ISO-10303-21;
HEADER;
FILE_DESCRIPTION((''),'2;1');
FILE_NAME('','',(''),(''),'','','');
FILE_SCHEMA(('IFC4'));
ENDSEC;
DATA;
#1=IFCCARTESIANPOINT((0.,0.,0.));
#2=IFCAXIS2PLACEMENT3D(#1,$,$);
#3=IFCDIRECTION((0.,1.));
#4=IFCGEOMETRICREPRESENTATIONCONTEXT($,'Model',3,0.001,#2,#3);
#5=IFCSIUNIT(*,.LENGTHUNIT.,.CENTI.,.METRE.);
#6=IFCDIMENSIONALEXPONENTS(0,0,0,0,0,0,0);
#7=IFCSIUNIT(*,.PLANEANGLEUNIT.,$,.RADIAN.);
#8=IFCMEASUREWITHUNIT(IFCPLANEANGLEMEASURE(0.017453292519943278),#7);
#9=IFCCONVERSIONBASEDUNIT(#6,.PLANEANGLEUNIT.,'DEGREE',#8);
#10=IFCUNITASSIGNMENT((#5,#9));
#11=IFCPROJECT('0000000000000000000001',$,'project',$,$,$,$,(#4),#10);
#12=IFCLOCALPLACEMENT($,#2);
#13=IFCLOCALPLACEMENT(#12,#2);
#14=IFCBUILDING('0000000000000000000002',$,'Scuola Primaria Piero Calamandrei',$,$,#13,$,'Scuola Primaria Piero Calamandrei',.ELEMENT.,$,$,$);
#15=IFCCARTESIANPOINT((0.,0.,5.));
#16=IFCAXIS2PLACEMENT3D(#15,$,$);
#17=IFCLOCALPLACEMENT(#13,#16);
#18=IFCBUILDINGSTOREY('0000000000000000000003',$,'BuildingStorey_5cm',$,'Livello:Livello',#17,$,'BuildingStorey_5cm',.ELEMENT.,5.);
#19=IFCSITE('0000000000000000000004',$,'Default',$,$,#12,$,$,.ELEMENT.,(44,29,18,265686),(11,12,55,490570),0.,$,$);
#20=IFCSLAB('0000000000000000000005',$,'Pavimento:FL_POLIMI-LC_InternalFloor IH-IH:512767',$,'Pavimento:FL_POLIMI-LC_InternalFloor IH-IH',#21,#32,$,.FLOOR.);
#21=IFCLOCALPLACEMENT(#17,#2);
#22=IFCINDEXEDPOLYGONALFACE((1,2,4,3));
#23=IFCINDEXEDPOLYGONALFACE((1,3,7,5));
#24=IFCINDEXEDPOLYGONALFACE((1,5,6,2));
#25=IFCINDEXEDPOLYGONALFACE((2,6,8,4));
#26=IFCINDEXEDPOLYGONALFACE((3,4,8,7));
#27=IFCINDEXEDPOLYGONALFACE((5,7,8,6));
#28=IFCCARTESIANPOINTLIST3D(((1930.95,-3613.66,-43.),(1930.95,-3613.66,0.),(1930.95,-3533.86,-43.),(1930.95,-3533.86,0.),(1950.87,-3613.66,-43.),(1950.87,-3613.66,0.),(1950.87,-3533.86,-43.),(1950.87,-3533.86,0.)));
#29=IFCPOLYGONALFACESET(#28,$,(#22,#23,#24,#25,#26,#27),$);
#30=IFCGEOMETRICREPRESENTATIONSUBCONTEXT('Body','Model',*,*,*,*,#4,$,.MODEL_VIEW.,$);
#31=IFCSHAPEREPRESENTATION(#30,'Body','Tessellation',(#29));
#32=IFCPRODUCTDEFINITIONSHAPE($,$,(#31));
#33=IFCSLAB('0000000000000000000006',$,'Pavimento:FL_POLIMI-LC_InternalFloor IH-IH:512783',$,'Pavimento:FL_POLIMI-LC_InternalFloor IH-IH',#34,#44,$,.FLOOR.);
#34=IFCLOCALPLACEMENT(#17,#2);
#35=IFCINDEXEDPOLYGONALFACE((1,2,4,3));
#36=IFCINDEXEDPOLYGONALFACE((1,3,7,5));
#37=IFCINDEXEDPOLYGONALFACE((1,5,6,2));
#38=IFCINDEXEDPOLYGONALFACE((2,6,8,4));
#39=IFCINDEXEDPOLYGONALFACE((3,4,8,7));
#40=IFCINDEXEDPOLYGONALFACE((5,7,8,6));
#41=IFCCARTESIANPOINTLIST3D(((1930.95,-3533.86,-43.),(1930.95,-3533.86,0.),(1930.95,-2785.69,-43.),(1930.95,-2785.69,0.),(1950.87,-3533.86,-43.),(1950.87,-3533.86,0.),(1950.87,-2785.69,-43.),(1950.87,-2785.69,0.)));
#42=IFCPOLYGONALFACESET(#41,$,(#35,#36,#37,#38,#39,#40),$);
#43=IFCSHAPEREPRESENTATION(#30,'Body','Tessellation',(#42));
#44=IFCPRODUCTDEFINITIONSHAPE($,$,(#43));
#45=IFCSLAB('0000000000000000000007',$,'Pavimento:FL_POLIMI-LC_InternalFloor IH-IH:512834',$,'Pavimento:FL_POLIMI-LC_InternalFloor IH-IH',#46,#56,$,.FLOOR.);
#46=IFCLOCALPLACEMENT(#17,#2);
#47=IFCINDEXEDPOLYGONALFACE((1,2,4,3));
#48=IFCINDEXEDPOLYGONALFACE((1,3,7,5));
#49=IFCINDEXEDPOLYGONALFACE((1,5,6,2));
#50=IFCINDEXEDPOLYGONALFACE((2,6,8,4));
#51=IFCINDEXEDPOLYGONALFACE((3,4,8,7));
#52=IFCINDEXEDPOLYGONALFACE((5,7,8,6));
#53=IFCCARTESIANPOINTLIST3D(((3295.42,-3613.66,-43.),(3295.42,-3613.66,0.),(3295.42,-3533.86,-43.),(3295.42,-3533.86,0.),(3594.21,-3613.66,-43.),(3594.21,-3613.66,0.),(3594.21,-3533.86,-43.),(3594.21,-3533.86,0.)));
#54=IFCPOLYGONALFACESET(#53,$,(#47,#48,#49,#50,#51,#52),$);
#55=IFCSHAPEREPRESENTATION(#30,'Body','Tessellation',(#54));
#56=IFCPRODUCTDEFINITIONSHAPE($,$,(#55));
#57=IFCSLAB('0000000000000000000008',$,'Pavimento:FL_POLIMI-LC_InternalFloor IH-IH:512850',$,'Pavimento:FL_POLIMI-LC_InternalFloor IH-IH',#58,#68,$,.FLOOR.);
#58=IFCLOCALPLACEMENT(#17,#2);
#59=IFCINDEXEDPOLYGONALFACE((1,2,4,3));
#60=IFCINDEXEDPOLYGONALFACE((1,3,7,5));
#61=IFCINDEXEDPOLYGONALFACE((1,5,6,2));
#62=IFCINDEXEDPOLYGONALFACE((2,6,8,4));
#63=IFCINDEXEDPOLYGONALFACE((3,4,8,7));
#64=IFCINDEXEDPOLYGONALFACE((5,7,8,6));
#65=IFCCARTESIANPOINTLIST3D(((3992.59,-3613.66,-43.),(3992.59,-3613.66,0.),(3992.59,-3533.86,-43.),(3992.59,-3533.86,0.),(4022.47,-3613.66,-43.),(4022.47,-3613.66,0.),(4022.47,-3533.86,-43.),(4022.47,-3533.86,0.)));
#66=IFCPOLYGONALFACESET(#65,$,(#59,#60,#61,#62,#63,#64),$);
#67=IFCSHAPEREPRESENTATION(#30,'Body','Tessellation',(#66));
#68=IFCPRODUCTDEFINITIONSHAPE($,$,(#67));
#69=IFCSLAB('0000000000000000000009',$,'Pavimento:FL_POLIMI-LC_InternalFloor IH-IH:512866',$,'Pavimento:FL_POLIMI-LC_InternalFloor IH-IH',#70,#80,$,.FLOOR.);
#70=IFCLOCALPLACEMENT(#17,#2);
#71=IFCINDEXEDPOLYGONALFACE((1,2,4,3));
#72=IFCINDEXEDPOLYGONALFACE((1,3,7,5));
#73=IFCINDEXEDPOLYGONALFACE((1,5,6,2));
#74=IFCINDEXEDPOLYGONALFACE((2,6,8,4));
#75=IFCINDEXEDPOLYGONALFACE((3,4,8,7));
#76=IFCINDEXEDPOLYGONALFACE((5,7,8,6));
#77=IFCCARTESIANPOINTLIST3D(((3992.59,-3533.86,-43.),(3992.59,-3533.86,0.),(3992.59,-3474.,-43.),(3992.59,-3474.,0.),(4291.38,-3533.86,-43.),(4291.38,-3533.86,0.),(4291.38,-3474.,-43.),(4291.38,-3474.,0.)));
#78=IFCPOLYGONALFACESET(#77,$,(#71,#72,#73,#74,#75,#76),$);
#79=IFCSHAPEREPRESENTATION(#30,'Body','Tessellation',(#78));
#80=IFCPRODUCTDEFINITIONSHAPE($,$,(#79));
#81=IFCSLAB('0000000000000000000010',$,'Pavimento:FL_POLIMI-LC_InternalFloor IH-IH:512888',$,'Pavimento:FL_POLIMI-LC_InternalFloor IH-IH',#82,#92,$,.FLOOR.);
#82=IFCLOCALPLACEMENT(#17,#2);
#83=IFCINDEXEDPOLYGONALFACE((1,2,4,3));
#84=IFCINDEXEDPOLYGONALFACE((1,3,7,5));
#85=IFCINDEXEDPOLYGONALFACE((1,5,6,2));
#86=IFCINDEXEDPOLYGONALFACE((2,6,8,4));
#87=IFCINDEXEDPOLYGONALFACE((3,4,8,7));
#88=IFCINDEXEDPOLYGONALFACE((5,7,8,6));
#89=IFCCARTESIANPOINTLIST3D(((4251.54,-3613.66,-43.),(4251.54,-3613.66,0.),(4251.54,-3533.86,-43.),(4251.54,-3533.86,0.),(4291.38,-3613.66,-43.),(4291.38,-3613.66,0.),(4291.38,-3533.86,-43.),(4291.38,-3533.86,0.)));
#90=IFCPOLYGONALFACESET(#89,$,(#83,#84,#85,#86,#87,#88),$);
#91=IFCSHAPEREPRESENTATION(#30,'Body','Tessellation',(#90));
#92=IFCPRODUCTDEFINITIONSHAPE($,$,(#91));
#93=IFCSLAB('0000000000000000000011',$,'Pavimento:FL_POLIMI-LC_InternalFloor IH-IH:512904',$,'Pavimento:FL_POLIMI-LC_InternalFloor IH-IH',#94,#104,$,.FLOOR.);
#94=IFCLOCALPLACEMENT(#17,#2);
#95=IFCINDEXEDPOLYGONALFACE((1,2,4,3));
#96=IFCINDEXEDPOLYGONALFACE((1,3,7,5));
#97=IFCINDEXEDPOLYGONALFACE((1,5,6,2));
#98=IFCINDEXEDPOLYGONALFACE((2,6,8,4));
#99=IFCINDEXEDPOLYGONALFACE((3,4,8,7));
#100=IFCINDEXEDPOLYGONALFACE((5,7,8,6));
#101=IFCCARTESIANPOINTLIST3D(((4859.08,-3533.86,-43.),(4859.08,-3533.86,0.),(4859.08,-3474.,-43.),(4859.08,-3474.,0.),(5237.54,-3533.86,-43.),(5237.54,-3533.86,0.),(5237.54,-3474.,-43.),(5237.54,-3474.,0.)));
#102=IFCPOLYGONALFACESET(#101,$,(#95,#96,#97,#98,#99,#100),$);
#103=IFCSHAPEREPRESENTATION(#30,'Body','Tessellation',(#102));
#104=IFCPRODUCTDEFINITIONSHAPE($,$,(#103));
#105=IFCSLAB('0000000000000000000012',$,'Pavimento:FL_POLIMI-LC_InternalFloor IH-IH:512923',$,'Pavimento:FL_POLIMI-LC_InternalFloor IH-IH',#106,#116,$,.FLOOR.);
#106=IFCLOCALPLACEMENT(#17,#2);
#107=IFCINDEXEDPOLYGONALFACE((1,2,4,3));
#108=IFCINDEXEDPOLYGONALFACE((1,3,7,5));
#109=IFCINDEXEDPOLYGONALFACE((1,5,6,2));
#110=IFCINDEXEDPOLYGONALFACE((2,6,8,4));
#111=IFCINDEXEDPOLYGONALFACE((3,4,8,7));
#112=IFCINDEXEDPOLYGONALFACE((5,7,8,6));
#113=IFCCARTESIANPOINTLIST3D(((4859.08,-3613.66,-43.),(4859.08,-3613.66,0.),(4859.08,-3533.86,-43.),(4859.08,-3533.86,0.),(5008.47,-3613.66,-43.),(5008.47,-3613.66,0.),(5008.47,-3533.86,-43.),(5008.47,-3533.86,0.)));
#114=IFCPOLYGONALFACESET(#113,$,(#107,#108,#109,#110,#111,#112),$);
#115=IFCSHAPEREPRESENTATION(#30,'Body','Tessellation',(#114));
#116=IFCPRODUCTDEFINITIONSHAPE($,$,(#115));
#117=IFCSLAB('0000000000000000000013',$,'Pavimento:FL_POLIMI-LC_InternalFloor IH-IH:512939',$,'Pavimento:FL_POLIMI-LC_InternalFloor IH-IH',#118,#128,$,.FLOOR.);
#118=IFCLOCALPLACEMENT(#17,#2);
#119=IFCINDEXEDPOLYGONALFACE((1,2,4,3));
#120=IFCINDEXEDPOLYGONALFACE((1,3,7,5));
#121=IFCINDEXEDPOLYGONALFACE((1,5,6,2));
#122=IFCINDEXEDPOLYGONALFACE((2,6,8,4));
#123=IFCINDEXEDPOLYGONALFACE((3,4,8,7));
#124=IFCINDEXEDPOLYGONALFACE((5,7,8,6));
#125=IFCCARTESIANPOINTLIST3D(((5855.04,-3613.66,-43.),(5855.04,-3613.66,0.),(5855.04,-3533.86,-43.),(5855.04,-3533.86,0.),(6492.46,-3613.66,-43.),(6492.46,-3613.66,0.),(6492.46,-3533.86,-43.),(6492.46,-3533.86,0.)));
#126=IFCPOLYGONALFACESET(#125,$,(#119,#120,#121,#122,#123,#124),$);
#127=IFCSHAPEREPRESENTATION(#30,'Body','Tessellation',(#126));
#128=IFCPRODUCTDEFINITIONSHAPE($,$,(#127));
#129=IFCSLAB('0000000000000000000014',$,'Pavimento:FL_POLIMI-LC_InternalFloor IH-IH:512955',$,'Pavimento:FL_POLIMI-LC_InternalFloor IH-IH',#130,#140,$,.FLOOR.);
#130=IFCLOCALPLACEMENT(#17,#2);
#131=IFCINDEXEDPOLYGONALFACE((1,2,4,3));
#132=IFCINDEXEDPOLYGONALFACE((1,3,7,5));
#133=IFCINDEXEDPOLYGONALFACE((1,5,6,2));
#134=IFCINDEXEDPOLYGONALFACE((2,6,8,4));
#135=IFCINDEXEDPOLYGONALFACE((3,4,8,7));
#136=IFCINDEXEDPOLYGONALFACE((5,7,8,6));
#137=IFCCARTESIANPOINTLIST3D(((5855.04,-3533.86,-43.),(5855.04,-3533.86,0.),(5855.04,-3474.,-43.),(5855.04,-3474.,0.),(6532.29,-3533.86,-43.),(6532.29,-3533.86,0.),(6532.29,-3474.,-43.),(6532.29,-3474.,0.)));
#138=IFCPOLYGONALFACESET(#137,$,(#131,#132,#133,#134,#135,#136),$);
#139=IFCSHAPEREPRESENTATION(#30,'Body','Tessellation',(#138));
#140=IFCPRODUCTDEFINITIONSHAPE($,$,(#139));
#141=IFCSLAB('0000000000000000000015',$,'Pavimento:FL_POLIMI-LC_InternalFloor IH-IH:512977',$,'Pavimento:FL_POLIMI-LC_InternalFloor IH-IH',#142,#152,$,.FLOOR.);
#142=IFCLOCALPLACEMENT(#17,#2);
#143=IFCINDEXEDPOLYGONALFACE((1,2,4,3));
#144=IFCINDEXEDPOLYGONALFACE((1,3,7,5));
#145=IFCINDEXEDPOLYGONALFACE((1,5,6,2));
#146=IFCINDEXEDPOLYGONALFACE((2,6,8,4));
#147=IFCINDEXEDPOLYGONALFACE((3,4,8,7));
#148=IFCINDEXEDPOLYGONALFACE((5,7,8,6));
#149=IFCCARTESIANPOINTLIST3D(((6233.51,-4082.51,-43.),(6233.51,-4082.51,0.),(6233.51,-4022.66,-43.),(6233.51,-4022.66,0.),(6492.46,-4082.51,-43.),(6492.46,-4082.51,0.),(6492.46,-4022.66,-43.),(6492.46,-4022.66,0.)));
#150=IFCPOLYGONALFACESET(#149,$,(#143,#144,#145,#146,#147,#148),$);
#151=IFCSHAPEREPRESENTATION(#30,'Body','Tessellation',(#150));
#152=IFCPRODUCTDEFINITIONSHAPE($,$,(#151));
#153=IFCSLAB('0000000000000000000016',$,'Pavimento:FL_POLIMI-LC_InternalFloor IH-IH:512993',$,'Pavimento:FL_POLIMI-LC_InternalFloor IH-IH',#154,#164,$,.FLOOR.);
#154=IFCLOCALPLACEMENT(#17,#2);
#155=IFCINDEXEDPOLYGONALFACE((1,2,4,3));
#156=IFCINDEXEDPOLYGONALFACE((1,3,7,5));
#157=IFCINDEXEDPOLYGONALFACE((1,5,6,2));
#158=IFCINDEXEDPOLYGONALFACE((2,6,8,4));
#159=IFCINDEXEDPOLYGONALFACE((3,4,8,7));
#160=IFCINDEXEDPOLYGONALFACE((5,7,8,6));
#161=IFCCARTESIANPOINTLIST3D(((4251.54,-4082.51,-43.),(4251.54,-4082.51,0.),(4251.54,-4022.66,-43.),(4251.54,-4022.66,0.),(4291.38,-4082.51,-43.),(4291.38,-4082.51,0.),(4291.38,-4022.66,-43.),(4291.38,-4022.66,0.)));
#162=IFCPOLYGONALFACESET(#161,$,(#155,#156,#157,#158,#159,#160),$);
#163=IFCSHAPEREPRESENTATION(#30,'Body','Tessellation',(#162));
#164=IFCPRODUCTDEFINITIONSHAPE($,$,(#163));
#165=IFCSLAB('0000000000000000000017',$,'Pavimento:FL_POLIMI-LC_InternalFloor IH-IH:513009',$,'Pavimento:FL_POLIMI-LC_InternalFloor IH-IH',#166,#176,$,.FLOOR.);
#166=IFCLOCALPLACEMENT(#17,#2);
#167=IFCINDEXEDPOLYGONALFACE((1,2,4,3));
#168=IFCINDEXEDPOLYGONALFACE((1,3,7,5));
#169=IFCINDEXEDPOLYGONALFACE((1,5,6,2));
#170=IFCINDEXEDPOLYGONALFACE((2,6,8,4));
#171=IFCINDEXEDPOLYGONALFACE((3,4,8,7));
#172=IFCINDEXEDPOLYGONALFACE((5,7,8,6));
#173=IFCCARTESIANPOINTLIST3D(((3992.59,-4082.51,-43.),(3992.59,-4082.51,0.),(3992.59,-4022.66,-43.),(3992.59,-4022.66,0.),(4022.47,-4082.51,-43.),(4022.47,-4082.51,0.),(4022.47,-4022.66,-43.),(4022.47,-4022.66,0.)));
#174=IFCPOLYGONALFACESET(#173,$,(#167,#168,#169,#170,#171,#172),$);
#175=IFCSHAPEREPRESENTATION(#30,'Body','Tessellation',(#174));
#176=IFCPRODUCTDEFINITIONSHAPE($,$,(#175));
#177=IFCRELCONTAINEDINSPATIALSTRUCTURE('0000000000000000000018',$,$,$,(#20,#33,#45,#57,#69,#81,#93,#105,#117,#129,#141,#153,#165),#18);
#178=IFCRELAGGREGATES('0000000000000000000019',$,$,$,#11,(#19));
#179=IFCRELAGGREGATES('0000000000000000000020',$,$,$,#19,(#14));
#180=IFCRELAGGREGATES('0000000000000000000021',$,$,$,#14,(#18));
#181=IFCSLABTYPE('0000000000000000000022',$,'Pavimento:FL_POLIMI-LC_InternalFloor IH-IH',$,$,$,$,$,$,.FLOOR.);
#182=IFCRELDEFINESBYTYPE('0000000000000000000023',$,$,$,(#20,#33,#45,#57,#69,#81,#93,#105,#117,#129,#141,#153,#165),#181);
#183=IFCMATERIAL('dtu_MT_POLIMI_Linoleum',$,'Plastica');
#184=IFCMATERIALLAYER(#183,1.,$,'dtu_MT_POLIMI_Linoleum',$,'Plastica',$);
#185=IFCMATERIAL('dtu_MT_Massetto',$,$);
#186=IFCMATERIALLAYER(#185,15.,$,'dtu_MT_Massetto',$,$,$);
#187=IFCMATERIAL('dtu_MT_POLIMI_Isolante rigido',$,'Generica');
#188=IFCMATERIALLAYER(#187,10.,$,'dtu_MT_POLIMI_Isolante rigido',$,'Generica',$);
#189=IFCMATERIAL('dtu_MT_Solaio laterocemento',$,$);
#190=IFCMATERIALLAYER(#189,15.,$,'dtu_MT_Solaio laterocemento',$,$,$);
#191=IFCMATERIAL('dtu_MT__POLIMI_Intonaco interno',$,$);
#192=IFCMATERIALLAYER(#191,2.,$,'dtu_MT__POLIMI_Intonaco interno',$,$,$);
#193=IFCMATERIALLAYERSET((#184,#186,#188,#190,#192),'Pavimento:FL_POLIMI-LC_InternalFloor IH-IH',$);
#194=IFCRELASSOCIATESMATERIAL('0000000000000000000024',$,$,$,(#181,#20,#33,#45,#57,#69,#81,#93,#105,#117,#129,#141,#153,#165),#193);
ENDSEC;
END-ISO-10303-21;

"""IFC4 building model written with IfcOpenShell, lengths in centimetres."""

from ifc_helpers import new_model, entity, si_unit, converted_unit, direction, frame, frame_2d, origin, origin_2d_with_axis, place, context, subcontext, project, spatial, rectangle, extrude, material, layer, layer_set, layer_usage, type_object, element, save


model = new_model("IFC4")

# Units and contexts
model_context = context("Model", 3, precision=0.001, world=origin(), true_north=direction((0.0, 1.0)))
body_context = subcontext(model_context, "Body", "Model", "MODEL_VIEW")
ifc_project = project(units=[si_unit("LENGTHUNIT", "METRE", prefix="CENTI"), converted_unit("PLANEANGLEUNIT", "DEGREE", entity("IfcPlaneAngleMeasure", 0.017453292519943278), si_unit("PLANEANGLEUNIT", "RADIAN"), dimensions=[0, 0, 0, 0, 0, 0, 0])], contexts=[model_context])

# Site, building, storey
site_placement = place(None, origin())
site = spatial("IfcSite", under=ifc_project, at=site_placement, Name="Default", CompositionType="ELEMENT", RefLatitude=(44, 29, 18, 265686), RefLongitude=(11, 12, 55, 490570), RefElevation=0.0)
building_placement = place(site_placement, origin())
building = spatial("IfcBuilding", under=site, at=building_placement, Name="Scuola Primaria Piero Calamandrei", LongName="Scuola Primaria Piero Calamandrei", CompositionType="ELEMENT")
storey_placement = place(building_placement, frame((0.0, 0.0, 5.0)))
storey = spatial("IfcBuildingStorey", under=building, at=storey_placement, Name="BuildingStorey_5cm", ObjectType="Livello:Livello", LongName="BuildingStorey_5cm", CompositionType="ELEMENT", Elevation=5.0)

# Slabs
ifc_material_1 = material(Name="dtu_MT_POLIMI_Linoleum", Category="Plastica")
ifc_layer_1 = layer(ifc_material_1, 1.0, Name="dtu_MT_POLIMI_Linoleum", Category="Plastica")
ifc_material_2 = material(Name="dtu_MT_Massetto")
ifc_layer_2 = layer(ifc_material_2, 15.0, Name="dtu_MT_Massetto")
ifc_material_3 = material(Name="dtu_MT_POLIMI_Isolante rigido", Category="Generica")
ifc_layer_3 = layer(ifc_material_3, 10.0, Name="dtu_MT_POLIMI_Isolante rigido", Category="Generica")
ifc_material_4 = material(Name="dtu_MT_Solaio laterocemento")
ifc_layer_4 = layer(ifc_material_4, 15.0, Name="dtu_MT_Solaio laterocemento")
ifc_material_5 = material(Name="dtu_MT__POLIMI_Intonaco interno")
ifc_layer_5 = layer(ifc_material_5, 2.0, Name="dtu_MT__POLIMI_Intonaco interno")
ifc_layer_set_1 = layer_set([ifc_layer_1, ifc_layer_2, ifc_layer_3, ifc_layer_4, ifc_layer_5], Name="Pavimento:FL_POLIMI-LC_InternalFloor IH-IH")
ifc_layer_usage_1 = layer_usage(ifc_layer_set_1, "AXIS3", "POSITIVE", 0.0)
slab_type_1 = type_object("IfcSlabType", Name="Pavimento:FL_POLIMI-LC_InternalFloor IH-IH", PredefinedType="FLOOR", material=ifc_layer_set_1)
slab_1_placement = place(storey_placement, origin())
element("IfcSlab", 1, at=slab_1_placement, inside=storey, type_object=slab_type_1, material=ifc_layer_usage_1, Name="Pavimento:FL_POLIMI-LC_InternalFloor IH-IH:512767", ObjectType="Pavimento:FL_POLIMI-LC_InternalFloor IH-IH", PredefinedType="FLOOR", context=body_context, shape_type="SweptSolid", body=[
    extrude(rectangle(XDim=79.8, YDim=19.92, at=frame_2d((0.0, 0.0), x_axis=(1.0, 0.0))), frame((1940.91, -3573.76, 0.0), z_axis=(0.0, 0.0, -1.0), x_axis=(0.0, 1.0, 0.0)), (0.0, 0.0, 1.0), 43.0),
])
ifc_layer_usage_2 = layer_usage(ifc_layer_set_1, "AXIS3", "POSITIVE", 0.0)
slab_2_placement = place(storey_placement, origin())
element("IfcSlab", 2, at=slab_2_placement, inside=storey, type_object=slab_type_1, material=ifc_layer_usage_2, Name="Pavimento:FL_POLIMI-LC_InternalFloor IH-IH:512783", ObjectType="Pavimento:FL_POLIMI-LC_InternalFloor IH-IH", PredefinedType="FLOOR", context=body_context, shape_type="SweptSolid", body=[
    extrude(rectangle(XDim=748.17, YDim=19.92, at=frame_2d((0.0, 0.0), x_axis=(1.0, 0.0))), frame((1940.91, -3159.77, 0.0), z_axis=(0.0, 0.0, -1.0), x_axis=(0.0, 1.0, 0.0)), (0.0, 0.0, 1.0), 43.0),
])
ifc_layer_usage_3 = layer_usage(ifc_layer_set_1, "AXIS3", "POSITIVE", 0.0)
slab_3_placement = place(storey_placement, origin())
element("IfcSlab", 3, at=slab_3_placement, inside=storey, type_object=slab_type_1, material=ifc_layer_usage_3, Name="Pavimento:FL_POLIMI-LC_InternalFloor IH-IH:512834", ObjectType="Pavimento:FL_POLIMI-LC_InternalFloor IH-IH", PredefinedType="FLOOR", context=body_context, shape_type="SweptSolid", body=[
    extrude(rectangle(XDim=79.8, YDim=298.79, at=origin_2d_with_axis()), frame((3444.81, -3573.76, 0.0), z_axis=(0.0, 0.0, -1.0), x_axis=(0.0, 1.0, 0.0)), (0.0, 0.0, 1.0), 43.0),
])
ifc_layer_usage_4 = layer_usage(ifc_layer_set_1, "AXIS3", "POSITIVE", 0.0)
slab_4_placement = place(storey_placement, origin())
element("IfcSlab", 4, at=slab_4_placement, inside=storey, type_object=slab_type_1, material=ifc_layer_usage_4, Name="Pavimento:FL_POLIMI-LC_InternalFloor IH-IH:512850", ObjectType="Pavimento:FL_POLIMI-LC_InternalFloor IH-IH", PredefinedType="FLOOR", context=body_context, shape_type="SweptSolid", body=[
    extrude(rectangle(XDim=79.8, YDim=29.88, at=origin_2d_with_axis()), frame((4007.53, -3573.76, 0.0), z_axis=(0.0, 0.0, -1.0), x_axis=(0.0, 1.0, 0.0)), (0.0, 0.0, 1.0), 43.0),
])
ifc_layer_usage_5 = layer_usage(ifc_layer_set_1, "AXIS3", "POSITIVE", 0.0)
slab_5_placement = place(storey_placement, origin())
element("IfcSlab", 5, at=slab_5_placement, inside=storey, type_object=slab_type_1, material=ifc_layer_usage_5, Name="Pavimento:FL_POLIMI-LC_InternalFloor IH-IH:512866", ObjectType="Pavimento:FL_POLIMI-LC_InternalFloor IH-IH", PredefinedType="FLOOR", context=body_context, shape_type="SweptSolid", body=[
    extrude(rectangle(XDim=59.85, YDim=298.79, at=frame_2d((0.0, 0.0), x_axis=(1.0, 0.0))), frame((4141.99, -3503.93, 0.0), z_axis=(0.0, 0.0, -1.0), x_axis=(0.0, 1.0, 0.0)), (0.0, 0.0, 1.0), 43.0),
])
ifc_layer_usage_6 = layer_usage(ifc_layer_set_1, "AXIS3", "POSITIVE", 0.0)
slab_6_placement = place(storey_placement, origin())
element("IfcSlab", 6, at=slab_6_placement, inside=storey, type_object=slab_type_1, material=ifc_layer_usage_6, Name="Pavimento:FL_POLIMI-LC_InternalFloor IH-IH:512888", ObjectType="Pavimento:FL_POLIMI-LC_InternalFloor IH-IH", PredefinedType="FLOOR", context=body_context, shape_type="SweptSolid", body=[
    extrude(rectangle(XDim=79.8, YDim=39.84, at=frame_2d((0.0, 0.0), x_axis=(1.0, 0.0))), frame((4271.46, -3573.76, 0.0), z_axis=(0.0, 0.0, -1.0), x_axis=(0.0, 1.0, 0.0)), (0.0, 0.0, 1.0), 43.0),
])
ifc_layer_usage_7 = layer_usage(ifc_layer_set_1, "AXIS3", "POSITIVE", 0.0)
slab_7_placement = place(storey_placement, origin())
element("IfcSlab", 7, at=slab_7_placement, inside=storey, type_object=slab_type_1, material=ifc_layer_usage_7, Name="Pavimento:FL_POLIMI-LC_InternalFloor IH-IH:512904", ObjectType="Pavimento:FL_POLIMI-LC_InternalFloor IH-IH", PredefinedType="FLOOR", context=body_context, shape_type="SweptSolid", body=[
    extrude(rectangle(XDim=59.85, YDim=378.47, at=frame_2d((0.0, 0.0), x_axis=(1.0, 0.0))), frame((5048.31, -3503.93, 0.0), z_axis=(0.0, 0.0, -1.0), x_axis=(0.0, 1.0, 0.0)), (0.0, 0.0, 1.0), 43.0),
])
ifc_layer_usage_8 = layer_usage(ifc_layer_set_1, "AXIS3", "POSITIVE", 0.0)
slab_8_placement = place(storey_placement, origin())
element("IfcSlab", 8, at=slab_8_placement, inside=storey, type_object=slab_type_1, material=ifc_layer_usage_8, Name="Pavimento:FL_POLIMI-LC_InternalFloor IH-IH:512923", ObjectType="Pavimento:FL_POLIMI-LC_InternalFloor IH-IH", PredefinedType="FLOOR", context=body_context, shape_type="SweptSolid", body=[
    extrude(rectangle(XDim=79.8, YDim=149.39, at=origin_2d_with_axis()), frame((4933.78, -3573.76, 0.0), z_axis=(0.0, 0.0, -1.0), x_axis=(0.0, 1.0, 0.0)), (0.0, 0.0, 1.0), 43.0),
])
ifc_layer_usage_9 = layer_usage(ifc_layer_set_1, "AXIS3", "POSITIVE", 0.0)
slab_9_placement = place(storey_placement, origin())
element("IfcSlab", 9, at=slab_9_placement, inside=storey, type_object=slab_type_1, material=ifc_layer_usage_9, Name="Pavimento:FL_POLIMI-LC_InternalFloor IH-IH:512939", ObjectType="Pavimento:FL_POLIMI-LC_InternalFloor IH-IH", PredefinedType="FLOOR", context=body_context, shape_type="SweptSolid", body=[
    extrude(rectangle(XDim=79.8, YDim=637.42, at=origin_2d_with_axis()), frame((6173.75, -3573.76, 0.0), z_axis=(0.0, 0.0, -1.0), x_axis=(0.0, 1.0, 0.0)), (0.0, 0.0, 1.0), 43.0),
])
ifc_layer_usage_10 = layer_usage(ifc_layer_set_1, "AXIS3", "POSITIVE", 0.0)
slab_10_placement = place(storey_placement, origin())
element("IfcSlab", 10, at=slab_10_placement, inside=storey, type_object=slab_type_1, material=ifc_layer_usage_10, Name="Pavimento:FL_POLIMI-LC_InternalFloor IH-IH:512955", ObjectType="Pavimento:FL_POLIMI-LC_InternalFloor IH-IH", PredefinedType="FLOOR", context=body_context, shape_type="SweptSolid", body=[
    extrude(rectangle(XDim=59.85, YDim=677.25, at=frame_2d((0.0, 0.0), x_axis=(1.0, 0.0))), frame((6193.67, -3503.93, 0.0), z_axis=(0.0, 0.0, -1.0), x_axis=(0.0, 1.0, 0.0)), (0.0, 0.0, 1.0), 43.0),
])
ifc_layer_usage_11 = layer_usage(ifc_layer_set_1, "AXIS3", "POSITIVE", 0.0)
slab_11_placement = place(storey_placement, origin())
element("IfcSlab", 11, at=slab_11_placement, inside=storey, type_object=slab_type_1, material=ifc_layer_usage_11, Name="Pavimento:FL_POLIMI-LC_InternalFloor IH-IH:512977", ObjectType="Pavimento:FL_POLIMI-LC_InternalFloor IH-IH", PredefinedType="FLOOR", context=body_context, shape_type="SweptSolid", body=[
    extrude(rectangle(XDim=59.85, YDim=258.95, at=frame_2d((0.0, 0.0), x_axis=(1.0, 0.0))), frame((6362.98, -4052.58, 0.0), z_axis=(0.0, 0.0, -1.0), x_axis=(0.0, 1.0, 0.0)), (0.0, 0.0, 1.0), 43.0),
])
ifc_layer_usage_12 = layer_usage(ifc_layer_set_1, "AXIS3", "POSITIVE", 0.0)
slab_12_placement = place(storey_placement, origin())
element("IfcSlab", 12, at=slab_12_placement, inside=storey, type_object=slab_type_1, material=ifc_layer_usage_12, Name="Pavimento:FL_POLIMI-LC_InternalFloor IH-IH:512993", ObjectType="Pavimento:FL_POLIMI-LC_InternalFloor IH-IH", PredefinedType="FLOOR", context=body_context, shape_type="SweptSolid", body=[
    extrude(rectangle(XDim=59.85, YDim=39.84, at=frame_2d((0.0, 0.0), x_axis=(1.0, 0.0))), frame((4271.46, -4052.58, 0.0), z_axis=(0.0, 0.0, -1.0), x_axis=(0.0, 1.0, 0.0)), (0.0, 0.0, 1.0), 43.0),
])
ifc_layer_usage_13 = layer_usage(ifc_layer_set_1, "AXIS3", "POSITIVE", 0.0)
slab_13_placement = place(storey_placement, origin())
element("IfcSlab", 13, at=slab_13_placement, inside=storey, type_object=slab_type_1, material=ifc_layer_usage_13, Name="Pavimento:FL_POLIMI-LC_InternalFloor IH-IH:513009", ObjectType="Pavimento:FL_POLIMI-LC_InternalFloor IH-IH", PredefinedType="FLOOR", context=body_context, shape_type="SweptSolid", body=[
    extrude(rectangle(XDim=59.85, YDim=29.88, at=frame_2d((0.0, 0.0), x_axis=(1.0, 0.0))), frame((4007.53, -4052.58, 0.0), z_axis=(0.0, 0.0, -1.0), x_axis=(0.0, 1.0, 0.0)), (0.0, 0.0, 1.0), 43.0),
])

save(model, "model.ifc")
